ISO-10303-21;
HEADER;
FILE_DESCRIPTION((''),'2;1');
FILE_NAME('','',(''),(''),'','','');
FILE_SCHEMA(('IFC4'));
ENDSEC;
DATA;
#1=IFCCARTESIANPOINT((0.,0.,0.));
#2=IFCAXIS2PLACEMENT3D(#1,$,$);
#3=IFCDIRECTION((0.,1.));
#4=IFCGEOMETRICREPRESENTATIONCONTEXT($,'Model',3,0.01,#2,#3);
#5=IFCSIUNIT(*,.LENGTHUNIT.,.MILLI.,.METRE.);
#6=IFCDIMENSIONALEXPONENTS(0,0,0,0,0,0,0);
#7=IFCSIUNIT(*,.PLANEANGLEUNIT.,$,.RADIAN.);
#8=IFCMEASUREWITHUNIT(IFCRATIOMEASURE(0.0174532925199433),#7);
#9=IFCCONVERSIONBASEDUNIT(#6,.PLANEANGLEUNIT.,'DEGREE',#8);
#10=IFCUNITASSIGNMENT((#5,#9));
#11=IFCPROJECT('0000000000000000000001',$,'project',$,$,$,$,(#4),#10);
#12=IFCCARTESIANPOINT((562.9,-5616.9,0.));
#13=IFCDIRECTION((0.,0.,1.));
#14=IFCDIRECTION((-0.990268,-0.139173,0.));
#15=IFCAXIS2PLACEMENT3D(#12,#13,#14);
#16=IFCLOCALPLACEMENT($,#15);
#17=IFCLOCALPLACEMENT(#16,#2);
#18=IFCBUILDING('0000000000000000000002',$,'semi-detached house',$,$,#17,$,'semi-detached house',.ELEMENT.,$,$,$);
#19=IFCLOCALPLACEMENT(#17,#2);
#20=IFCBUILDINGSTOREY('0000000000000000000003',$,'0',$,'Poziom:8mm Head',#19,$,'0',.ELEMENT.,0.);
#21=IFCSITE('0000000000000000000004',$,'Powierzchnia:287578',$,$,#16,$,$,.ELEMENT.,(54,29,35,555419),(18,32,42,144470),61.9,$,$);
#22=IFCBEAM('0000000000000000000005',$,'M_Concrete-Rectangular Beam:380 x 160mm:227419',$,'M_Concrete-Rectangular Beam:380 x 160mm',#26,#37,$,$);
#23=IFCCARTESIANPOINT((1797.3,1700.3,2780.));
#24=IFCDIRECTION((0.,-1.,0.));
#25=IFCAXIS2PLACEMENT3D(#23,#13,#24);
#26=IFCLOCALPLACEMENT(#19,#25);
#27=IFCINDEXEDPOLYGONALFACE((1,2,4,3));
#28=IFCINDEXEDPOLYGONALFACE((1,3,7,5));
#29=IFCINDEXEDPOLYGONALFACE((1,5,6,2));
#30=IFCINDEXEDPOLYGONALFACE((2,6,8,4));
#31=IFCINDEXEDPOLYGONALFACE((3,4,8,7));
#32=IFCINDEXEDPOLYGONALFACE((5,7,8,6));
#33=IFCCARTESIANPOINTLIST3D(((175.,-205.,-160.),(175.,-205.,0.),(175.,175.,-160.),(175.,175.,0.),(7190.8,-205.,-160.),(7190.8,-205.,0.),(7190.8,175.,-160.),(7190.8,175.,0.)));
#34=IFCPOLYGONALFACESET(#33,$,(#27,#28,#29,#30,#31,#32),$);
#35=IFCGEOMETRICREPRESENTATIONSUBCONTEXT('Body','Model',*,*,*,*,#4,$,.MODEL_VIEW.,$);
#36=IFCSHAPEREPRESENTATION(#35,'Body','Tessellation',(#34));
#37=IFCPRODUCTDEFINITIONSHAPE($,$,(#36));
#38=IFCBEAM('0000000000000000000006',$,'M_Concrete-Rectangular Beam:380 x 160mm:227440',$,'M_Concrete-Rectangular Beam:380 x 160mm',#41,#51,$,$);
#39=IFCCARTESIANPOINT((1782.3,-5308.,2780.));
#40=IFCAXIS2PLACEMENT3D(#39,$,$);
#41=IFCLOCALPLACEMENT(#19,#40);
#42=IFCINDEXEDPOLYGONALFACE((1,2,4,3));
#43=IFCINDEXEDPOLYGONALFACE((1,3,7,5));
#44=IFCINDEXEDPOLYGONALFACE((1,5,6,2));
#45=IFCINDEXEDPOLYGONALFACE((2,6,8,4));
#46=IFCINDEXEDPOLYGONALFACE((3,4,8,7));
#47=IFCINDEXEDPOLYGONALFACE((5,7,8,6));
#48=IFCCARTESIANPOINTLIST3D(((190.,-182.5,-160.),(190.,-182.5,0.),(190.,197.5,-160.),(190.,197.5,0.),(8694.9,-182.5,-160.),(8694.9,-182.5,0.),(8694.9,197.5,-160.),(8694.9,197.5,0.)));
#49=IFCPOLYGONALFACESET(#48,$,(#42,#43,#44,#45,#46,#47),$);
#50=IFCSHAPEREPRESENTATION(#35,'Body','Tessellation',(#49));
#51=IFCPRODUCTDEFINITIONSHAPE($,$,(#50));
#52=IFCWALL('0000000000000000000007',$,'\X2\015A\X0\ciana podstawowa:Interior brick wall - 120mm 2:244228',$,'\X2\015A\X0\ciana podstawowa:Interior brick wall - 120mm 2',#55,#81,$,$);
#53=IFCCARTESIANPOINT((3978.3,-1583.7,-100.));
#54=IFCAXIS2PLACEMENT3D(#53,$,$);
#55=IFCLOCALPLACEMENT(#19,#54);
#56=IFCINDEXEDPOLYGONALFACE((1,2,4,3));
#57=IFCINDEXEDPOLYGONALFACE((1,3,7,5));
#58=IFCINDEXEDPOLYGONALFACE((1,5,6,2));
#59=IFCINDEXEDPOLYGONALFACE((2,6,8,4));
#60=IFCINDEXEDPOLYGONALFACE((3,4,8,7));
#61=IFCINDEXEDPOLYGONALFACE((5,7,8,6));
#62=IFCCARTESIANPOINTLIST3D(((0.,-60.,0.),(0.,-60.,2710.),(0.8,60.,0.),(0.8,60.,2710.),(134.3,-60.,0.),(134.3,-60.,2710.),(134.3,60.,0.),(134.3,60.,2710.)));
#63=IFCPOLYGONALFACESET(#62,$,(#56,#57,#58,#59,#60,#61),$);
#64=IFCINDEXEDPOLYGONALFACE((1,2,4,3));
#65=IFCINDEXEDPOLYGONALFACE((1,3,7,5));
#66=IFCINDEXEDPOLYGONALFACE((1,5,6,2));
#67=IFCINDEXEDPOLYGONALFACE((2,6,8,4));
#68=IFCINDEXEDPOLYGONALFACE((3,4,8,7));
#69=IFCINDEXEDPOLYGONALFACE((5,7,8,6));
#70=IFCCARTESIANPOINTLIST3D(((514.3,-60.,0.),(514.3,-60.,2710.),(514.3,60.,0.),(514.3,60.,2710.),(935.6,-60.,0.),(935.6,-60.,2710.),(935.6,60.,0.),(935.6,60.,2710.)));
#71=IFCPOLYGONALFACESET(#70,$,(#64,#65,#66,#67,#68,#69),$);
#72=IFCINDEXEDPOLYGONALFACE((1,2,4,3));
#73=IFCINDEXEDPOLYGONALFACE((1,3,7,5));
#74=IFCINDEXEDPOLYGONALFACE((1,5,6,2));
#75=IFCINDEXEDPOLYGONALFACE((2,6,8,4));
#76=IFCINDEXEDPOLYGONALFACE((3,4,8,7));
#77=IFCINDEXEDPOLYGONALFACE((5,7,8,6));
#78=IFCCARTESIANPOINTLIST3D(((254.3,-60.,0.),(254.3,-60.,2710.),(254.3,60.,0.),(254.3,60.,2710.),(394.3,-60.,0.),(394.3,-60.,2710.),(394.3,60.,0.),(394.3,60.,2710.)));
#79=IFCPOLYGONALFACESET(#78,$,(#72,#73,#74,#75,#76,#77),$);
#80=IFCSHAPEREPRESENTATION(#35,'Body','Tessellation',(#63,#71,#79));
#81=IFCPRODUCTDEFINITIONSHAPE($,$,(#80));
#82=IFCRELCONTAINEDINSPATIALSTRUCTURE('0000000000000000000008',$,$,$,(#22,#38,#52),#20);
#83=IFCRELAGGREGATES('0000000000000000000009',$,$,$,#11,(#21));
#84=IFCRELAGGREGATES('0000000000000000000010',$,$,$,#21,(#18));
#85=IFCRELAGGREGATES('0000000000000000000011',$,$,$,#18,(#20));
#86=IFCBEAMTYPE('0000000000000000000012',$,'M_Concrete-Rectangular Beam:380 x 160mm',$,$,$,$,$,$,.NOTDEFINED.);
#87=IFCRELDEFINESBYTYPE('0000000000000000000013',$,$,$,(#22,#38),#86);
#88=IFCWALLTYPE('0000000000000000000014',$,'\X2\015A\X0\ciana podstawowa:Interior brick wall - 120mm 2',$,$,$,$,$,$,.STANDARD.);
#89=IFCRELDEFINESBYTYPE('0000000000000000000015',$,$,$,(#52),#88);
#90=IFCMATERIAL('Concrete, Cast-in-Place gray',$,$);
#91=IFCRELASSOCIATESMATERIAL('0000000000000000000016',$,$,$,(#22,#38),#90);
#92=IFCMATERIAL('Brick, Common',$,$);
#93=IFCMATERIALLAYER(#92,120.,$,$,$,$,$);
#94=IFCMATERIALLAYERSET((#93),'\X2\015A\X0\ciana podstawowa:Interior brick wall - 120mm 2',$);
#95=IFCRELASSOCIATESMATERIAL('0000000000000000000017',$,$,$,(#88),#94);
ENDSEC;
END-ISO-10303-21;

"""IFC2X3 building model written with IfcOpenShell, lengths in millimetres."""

from ifc_helpers import new_model, entity, si_unit, converted_unit, direction, frame, frame_2d, origin, origin_2d_with_axis, place, context, subcontext, project, spatial, polyline, rectangle, outline, extrude, material, layer, layer_set, type_object, element, save


model = new_model("IFC2X3")

# Units and contexts
model_context = context("Model", 3, precision=0.01, world=origin(), true_north=direction((0.0, 1.0)))
body_context = subcontext(model_context, "Body", "Model", "MODEL_VIEW")
ifc_project = project(units=[si_unit("LENGTHUNIT", "METRE", prefix="MILLI"), converted_unit("PLANEANGLEUNIT", "DEGREE", entity("IfcRatioMeasure", 0.0174532925199433), si_unit("PLANEANGLEUNIT", "RADIAN"), dimensions=[0, 0, 0, 0, 0, 0, 0])], contexts=[model_context])

# Site, building, storey
site_placement = place(None, frame((562.9, -5616.9, 0.0), z_axis=(0.0, 0.0, 1.0), x_axis=(-0.990268, -0.139173, 0.0)))
site = spatial("IfcSite", under=ifc_project, at=site_placement, Name="Powierzchnia:287578", CompositionType="ELEMENT", RefLatitude=(54, 29, 35, 555419), RefLongitude=(18, 32, 42, 144470), RefElevation=61.9)
building_placement = place(site_placement, origin())
building = spatial("IfcBuilding", under=site, at=building_placement, Name="semi-detached house", LongName="semi-detached house", CompositionType="ELEMENT")
storey_placement = place(building_placement, origin())
storey = spatial("IfcBuildingStorey", under=building, at=storey_placement, Name="0", ObjectType="Poziom:8mm Head", LongName="0", CompositionType="ELEMENT", Elevation=0.0)

# Beams
ifc_material_1 = material(Name="Concrete, Cast-in-Place gray")
beam_type_1 = type_object("IfcBeamType", Name="M_Concrete-Rectangular Beam:380 x 160mm", PredefinedType="NOTDEFINED")
beam_1_placement = place(storey_placement, frame((1797.3, 1700.3, 2780.0), z_axis=(0.0, 0.0, 1.0), x_axis=(0.0, -1.0, 0.0)))
element("IfcBeam", 1, at=beam_1_placement, inside=storey, type_object=beam_type_1, material=ifc_material_1, Name="M_Concrete-Rectangular Beam:380 x 160mm:227419", ObjectType="M_Concrete-Rectangular Beam:380 x 160mm", context=body_context, shape_type="SweptSolid", body=[
    extrude(rectangle(XDim=160.0, YDim=380.0, at=frame_2d((0.0, 0.0), x_axis=(1.0, 0.0))), frame((175.0, -15.0, -80.0), z_axis=(1.0, 0.0, 0.0), x_axis=(0.0, 0.0, -1.0)), (0.0, 0.0, 1.0), 7015.8),
])
beam_2_placement = place(storey_placement, frame((1782.3, -5308.0, 2780.0)))
element("IfcBeam", 2, at=beam_2_placement, inside=storey, type_object=beam_type_1, material=ifc_material_1, Name="M_Concrete-Rectangular Beam:380 x 160mm:227440", ObjectType="M_Concrete-Rectangular Beam:380 x 160mm", context=body_context, shape_type="SweptSolid", body=[
    extrude(rectangle(XDim=160.0, YDim=380.0, at=frame_2d((0.0, 0.0), x_axis=(1.0, 0.0))), frame((190.0, 7.5, -80.0), z_axis=(1.0, 0.0, 0.0), x_axis=(0.0, 0.0, -1.0)), (0.0, 0.0, 1.0), 8504.9),
])

# Shared definitions
ifc_material_2 = material(Name="Brick, Common")

# Wall
ifc_layer_1 = layer(ifc_material_2, 120.0)
ifc_layer_set_1 = layer_set([ifc_layer_1], Name="Ściana podstawowa:Interior brick wall - 120mm 2")
wall_type_1 = type_object("IfcWallType", Name="Ściana podstawowa:Interior brick wall - 120mm 2", PredefinedType="STANDARD", material=ifc_layer_set_1)
wall_1_placement = place(storey_placement, frame((3978.3, -1583.7, -100.0)))
element("IfcWall", 3, at=wall_1_placement, inside=storey, type_object=wall_type_1, Name="Ściana podstawowa:Interior brick wall - 120mm 2:244228", ObjectType="Ściana podstawowa:Interior brick wall - 120mm 2", context=body_context, shape_type="SweptSolid", body=[
    extrude(outline(polyline([(-67.4, -60.0), (67.0, -60.0), (67.0, 60.0), (-66.6, 60.0), (-67.4, -60.0)])), frame((67.4, 0.0, 0.0)), (0.0, 0.0, 1.0), 2710.0),
    extrude(rectangle(XDim=120.0, YDim=421.3, at=frame_2d((-20.0, -3.6), x_axis=(1.0, 0.0))), frame((721.4, 20.0, 0.0), z_axis=(0.0, 0.0, 1.0), x_axis=(0.0, 1.0, 0.0)), (0.0, 0.0, 1.0), 2710.0),
    extrude(rectangle(XDim=140.0, YDim=120.0, at=origin_2d_with_axis()), frame((324.3, 0.0, 0.0), z_axis=(0.0, 0.0, 1.0), x_axis=(-1.0, 0.0, 0.0)), (0.0, 0.0, 1.0), 2710.0),
])

save(model, "model.ifc")
